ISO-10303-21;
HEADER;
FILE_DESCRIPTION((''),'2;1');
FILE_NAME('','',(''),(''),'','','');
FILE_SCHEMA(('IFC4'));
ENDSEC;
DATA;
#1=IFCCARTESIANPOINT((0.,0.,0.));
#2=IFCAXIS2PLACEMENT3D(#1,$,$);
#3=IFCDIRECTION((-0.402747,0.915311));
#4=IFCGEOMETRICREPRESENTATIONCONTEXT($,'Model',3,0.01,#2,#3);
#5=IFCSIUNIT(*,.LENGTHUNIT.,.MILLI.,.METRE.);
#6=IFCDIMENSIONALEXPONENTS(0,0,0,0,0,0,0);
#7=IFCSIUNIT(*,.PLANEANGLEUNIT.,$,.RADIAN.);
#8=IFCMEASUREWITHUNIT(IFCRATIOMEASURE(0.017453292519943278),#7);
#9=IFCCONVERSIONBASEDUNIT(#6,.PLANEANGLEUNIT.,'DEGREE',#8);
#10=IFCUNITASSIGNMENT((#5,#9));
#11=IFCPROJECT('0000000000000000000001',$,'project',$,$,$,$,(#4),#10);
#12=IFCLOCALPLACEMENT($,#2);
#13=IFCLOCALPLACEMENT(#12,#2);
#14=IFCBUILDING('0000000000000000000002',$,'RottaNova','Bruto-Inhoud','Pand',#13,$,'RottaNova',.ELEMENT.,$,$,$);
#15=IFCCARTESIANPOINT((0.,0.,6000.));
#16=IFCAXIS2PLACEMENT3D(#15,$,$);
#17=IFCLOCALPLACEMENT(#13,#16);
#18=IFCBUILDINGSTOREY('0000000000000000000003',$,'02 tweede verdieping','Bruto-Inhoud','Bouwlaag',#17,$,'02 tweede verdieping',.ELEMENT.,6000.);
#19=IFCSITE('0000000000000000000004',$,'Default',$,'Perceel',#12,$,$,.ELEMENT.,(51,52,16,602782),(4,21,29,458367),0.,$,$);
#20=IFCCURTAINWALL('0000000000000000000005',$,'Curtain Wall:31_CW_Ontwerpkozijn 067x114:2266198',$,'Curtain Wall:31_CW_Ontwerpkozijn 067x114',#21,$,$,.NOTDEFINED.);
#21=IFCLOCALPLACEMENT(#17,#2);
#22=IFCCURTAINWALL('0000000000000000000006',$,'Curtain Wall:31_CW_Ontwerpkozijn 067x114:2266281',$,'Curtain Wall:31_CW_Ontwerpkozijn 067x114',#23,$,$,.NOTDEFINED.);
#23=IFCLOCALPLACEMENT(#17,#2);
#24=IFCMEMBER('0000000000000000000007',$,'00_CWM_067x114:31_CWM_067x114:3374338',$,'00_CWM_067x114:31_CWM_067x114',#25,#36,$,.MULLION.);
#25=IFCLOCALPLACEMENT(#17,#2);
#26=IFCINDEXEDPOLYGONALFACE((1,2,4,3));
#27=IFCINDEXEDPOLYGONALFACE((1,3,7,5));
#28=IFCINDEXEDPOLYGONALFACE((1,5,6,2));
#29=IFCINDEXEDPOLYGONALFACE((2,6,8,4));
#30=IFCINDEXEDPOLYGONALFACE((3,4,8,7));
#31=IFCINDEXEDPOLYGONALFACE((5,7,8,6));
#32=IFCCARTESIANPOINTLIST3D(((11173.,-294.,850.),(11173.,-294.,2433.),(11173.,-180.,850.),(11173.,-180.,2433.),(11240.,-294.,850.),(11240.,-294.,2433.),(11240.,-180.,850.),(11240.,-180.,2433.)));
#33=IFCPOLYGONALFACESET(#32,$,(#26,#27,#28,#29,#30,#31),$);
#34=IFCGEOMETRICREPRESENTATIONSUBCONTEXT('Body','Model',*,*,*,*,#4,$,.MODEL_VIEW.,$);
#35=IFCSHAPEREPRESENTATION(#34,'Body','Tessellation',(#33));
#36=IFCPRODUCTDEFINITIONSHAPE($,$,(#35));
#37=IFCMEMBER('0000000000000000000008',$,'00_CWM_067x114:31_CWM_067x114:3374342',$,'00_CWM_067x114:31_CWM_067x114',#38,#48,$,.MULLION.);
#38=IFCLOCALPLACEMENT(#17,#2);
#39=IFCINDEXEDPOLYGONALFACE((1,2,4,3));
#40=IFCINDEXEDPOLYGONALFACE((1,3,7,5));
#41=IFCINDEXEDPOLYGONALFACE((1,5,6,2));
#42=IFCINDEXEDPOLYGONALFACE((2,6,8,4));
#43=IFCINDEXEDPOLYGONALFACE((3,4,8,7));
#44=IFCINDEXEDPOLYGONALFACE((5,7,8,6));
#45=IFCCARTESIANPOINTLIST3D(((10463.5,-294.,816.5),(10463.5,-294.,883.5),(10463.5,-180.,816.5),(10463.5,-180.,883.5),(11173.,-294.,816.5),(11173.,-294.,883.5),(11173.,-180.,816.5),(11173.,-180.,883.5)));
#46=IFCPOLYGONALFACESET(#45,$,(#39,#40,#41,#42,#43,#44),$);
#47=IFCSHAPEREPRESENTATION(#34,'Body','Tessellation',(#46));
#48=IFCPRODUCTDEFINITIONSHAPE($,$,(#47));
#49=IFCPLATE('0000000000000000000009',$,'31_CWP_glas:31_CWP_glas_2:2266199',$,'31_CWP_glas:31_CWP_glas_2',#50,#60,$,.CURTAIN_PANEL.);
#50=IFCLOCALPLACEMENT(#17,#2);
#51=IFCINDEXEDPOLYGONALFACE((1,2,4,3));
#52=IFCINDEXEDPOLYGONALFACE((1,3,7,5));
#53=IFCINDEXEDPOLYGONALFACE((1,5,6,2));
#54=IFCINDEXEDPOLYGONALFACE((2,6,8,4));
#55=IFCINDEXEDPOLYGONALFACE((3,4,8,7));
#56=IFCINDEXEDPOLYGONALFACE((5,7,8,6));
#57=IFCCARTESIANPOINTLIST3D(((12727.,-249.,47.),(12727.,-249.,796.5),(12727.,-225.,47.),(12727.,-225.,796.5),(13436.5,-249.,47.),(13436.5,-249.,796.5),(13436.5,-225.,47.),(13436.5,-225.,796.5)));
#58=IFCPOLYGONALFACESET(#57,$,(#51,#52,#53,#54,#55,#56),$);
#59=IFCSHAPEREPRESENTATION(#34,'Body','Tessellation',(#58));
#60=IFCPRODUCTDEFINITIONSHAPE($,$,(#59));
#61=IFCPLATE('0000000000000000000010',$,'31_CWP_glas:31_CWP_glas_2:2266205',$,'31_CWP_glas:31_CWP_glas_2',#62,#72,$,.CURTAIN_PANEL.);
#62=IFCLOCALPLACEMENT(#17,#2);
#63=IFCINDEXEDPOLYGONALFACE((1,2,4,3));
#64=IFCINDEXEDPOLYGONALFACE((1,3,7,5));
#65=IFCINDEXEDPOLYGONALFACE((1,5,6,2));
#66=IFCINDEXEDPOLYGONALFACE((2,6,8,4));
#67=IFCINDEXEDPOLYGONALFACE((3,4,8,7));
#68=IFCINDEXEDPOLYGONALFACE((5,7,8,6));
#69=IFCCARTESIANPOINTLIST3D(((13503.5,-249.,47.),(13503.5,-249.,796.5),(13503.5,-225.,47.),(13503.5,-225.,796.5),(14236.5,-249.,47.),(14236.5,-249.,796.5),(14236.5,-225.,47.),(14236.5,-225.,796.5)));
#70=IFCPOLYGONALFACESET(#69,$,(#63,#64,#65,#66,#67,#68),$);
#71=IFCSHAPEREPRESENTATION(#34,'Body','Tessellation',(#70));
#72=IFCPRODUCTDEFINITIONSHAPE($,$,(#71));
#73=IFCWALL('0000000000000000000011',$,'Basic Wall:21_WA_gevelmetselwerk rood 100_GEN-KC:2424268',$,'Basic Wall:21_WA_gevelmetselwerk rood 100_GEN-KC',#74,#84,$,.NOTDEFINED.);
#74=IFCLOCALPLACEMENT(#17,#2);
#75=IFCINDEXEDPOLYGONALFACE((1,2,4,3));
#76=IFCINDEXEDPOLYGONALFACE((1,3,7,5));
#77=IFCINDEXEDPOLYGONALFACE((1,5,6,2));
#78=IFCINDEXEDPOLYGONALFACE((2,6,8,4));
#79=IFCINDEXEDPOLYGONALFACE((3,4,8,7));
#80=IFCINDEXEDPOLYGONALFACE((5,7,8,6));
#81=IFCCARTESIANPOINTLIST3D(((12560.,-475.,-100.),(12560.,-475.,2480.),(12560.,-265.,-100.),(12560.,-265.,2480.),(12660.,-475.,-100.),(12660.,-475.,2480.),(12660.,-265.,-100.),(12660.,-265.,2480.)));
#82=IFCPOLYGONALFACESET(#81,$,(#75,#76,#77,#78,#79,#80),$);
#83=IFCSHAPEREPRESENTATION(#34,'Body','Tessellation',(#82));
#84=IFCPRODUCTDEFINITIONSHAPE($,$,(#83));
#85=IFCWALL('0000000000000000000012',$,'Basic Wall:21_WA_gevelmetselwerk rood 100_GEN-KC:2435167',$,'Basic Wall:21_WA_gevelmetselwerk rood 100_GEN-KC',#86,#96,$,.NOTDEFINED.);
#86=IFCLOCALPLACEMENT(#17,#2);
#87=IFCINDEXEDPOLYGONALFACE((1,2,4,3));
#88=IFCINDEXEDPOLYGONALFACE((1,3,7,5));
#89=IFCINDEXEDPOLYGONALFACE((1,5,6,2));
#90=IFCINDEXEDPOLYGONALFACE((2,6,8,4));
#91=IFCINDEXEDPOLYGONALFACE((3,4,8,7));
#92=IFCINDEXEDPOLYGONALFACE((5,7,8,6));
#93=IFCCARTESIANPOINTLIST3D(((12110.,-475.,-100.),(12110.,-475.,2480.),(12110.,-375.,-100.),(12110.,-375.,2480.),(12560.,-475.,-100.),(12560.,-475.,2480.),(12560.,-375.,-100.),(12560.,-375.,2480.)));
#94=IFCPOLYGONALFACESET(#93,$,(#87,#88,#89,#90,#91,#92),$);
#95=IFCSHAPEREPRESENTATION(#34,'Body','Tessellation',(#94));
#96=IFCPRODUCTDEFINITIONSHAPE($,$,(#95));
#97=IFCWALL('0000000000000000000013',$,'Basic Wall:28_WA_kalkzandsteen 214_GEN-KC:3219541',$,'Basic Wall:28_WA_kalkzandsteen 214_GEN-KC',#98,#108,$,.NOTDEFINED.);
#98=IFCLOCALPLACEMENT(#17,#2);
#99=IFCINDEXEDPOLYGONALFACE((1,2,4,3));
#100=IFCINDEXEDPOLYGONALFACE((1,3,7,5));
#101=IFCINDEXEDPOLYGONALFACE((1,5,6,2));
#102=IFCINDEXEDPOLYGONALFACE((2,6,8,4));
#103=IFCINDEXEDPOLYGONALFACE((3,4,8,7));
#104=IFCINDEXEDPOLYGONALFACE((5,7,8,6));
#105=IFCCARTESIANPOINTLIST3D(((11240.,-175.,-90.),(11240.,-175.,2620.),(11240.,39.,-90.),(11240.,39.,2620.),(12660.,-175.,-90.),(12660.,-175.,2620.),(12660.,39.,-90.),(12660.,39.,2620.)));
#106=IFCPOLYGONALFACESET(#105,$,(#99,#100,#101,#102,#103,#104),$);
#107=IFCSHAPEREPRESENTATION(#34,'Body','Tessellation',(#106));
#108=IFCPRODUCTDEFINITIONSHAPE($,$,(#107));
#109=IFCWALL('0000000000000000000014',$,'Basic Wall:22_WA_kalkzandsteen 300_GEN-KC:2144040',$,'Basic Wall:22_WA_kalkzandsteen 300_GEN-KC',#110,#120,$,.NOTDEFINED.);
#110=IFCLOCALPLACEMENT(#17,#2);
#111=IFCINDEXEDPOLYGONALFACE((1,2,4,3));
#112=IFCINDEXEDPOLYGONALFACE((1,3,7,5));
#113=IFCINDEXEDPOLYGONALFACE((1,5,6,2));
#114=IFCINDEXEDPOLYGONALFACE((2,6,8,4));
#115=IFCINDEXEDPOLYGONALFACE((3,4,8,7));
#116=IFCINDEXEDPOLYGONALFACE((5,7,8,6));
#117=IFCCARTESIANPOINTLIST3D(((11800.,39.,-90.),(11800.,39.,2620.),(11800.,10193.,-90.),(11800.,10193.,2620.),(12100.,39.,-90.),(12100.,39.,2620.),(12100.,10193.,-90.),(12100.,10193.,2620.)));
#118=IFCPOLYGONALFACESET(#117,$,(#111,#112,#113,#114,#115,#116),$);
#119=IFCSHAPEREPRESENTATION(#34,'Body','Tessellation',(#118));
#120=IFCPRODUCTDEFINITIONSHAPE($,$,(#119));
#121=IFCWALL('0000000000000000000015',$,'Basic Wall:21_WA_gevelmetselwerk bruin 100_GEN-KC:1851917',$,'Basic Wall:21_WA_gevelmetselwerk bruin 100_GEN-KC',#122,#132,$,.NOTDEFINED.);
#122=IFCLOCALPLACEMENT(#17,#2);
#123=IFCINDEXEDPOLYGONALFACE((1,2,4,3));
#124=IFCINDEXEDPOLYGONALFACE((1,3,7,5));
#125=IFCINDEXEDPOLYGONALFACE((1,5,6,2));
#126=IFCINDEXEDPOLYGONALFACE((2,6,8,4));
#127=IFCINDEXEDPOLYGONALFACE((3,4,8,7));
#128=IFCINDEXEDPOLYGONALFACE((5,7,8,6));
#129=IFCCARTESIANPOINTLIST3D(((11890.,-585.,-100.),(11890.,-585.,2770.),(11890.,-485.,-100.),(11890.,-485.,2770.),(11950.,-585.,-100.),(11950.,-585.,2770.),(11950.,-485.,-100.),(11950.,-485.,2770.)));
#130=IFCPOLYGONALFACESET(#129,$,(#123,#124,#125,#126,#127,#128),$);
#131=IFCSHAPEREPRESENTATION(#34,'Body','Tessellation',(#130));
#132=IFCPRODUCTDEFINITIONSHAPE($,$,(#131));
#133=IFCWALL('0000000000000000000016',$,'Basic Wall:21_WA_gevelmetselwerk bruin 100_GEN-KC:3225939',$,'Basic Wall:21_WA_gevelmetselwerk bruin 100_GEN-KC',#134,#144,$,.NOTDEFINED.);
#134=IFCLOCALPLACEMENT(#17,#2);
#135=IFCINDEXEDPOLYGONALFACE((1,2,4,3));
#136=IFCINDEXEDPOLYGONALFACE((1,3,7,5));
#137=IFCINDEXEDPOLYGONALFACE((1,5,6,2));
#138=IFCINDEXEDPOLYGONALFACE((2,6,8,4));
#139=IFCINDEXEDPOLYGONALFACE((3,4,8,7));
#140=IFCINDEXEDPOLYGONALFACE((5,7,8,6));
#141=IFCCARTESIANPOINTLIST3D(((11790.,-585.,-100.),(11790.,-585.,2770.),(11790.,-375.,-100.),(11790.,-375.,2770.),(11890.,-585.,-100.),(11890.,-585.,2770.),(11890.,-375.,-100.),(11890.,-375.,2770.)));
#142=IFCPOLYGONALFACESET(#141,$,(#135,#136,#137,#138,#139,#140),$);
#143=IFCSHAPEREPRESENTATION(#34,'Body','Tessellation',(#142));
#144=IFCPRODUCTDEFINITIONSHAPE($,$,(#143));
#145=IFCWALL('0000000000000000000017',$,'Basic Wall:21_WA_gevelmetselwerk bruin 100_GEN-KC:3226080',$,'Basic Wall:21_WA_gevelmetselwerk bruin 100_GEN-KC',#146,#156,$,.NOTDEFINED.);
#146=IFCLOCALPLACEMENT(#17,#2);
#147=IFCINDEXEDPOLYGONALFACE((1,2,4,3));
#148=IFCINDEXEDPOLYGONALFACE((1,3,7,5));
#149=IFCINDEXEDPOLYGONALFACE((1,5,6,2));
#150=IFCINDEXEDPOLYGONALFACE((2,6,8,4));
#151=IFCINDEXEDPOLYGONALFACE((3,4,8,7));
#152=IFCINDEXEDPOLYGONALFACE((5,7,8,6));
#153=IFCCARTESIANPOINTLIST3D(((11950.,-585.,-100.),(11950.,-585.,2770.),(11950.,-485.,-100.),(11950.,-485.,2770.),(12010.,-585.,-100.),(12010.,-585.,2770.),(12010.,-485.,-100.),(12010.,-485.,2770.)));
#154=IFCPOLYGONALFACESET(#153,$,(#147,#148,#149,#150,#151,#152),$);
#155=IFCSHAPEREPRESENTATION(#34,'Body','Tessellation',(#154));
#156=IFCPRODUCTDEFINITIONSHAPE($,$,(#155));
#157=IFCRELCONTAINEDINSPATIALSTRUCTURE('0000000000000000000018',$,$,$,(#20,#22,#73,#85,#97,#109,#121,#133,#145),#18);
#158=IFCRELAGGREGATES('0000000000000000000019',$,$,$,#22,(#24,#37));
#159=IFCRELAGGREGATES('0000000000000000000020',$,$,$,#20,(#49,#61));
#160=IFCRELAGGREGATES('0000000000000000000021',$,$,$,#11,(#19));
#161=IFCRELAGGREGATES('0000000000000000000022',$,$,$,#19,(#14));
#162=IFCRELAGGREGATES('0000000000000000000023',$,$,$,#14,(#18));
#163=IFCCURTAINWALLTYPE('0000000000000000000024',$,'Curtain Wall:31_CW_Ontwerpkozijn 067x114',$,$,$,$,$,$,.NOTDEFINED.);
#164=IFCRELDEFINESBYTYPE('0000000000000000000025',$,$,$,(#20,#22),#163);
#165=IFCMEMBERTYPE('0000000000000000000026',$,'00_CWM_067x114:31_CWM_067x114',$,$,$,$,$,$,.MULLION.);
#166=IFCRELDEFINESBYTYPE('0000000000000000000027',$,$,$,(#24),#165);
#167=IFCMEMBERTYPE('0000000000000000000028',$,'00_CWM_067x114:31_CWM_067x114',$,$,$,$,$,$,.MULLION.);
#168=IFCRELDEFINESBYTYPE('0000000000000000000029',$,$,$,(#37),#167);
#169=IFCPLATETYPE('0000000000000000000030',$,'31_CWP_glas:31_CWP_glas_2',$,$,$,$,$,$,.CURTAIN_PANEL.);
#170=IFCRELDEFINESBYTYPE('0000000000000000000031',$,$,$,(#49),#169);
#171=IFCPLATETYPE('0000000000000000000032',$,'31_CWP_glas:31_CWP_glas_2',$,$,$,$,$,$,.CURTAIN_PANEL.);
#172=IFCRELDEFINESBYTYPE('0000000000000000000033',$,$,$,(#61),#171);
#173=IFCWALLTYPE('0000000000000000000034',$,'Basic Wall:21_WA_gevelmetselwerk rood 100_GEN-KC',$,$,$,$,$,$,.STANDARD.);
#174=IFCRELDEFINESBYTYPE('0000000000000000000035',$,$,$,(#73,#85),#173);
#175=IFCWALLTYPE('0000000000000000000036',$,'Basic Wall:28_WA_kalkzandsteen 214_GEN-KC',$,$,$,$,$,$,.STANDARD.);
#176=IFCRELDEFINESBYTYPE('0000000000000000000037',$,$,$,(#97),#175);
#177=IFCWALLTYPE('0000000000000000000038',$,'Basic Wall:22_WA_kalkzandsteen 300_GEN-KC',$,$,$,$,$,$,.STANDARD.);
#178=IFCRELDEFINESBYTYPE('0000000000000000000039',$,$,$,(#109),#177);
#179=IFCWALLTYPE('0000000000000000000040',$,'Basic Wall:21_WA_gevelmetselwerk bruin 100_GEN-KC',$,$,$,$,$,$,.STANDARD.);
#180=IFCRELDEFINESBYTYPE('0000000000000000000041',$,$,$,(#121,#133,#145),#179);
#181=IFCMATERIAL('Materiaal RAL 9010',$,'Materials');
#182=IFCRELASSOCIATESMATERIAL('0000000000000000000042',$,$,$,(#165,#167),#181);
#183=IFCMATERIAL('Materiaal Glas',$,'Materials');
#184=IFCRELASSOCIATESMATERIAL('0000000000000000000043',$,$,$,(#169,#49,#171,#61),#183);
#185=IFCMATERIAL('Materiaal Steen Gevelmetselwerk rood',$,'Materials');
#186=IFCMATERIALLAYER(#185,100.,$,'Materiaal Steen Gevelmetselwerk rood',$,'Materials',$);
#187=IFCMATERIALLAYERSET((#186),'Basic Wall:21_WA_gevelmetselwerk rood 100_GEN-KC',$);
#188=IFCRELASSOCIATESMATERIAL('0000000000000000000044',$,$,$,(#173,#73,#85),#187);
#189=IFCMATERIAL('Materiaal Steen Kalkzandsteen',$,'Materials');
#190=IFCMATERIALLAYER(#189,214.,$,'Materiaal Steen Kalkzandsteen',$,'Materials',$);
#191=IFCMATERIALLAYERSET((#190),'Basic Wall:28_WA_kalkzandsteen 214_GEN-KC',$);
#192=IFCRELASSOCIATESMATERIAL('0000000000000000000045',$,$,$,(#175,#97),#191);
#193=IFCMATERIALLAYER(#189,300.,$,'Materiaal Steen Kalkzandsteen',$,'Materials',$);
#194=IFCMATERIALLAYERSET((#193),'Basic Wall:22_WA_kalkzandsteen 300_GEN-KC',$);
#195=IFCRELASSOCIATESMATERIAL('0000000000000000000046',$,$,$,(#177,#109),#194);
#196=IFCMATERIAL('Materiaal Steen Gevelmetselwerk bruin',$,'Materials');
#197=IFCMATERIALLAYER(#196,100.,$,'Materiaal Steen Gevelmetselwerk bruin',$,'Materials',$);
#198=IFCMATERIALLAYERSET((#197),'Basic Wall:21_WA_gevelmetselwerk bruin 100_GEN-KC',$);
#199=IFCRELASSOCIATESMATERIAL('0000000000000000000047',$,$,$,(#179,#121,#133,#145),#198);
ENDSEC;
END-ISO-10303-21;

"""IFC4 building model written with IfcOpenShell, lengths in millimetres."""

from ifc_helpers import new_model, entity, si_unit, converted_unit, direction, frame, frame_2d, origin, origin_2d_with_axis, place, context, subcontext, project, spatial, rectangle, extrude, source, transform, mapped, material, layer, layer_set, material_profile, profile_set, type_object, type_shapes, element, aggregate, save


model = new_model("IFC4")

# Units and contexts
model_context = context("Model", 3, precision=0.01, world=origin(), true_north=direction((-0.402747, 0.915311)))
body_context = subcontext(model_context, "Body", "Model", "MODEL_VIEW")
ifc_project = project(units=[si_unit("LENGTHUNIT", "METRE", prefix="MILLI"), converted_unit("PLANEANGLEUNIT", "DEGREE", entity("IfcRatioMeasure", 0.017453292519943278), si_unit("PLANEANGLEUNIT", "RADIAN"), dimensions=[0, 0, 0, 0, 0, 0, 0])], contexts=[model_context])

# Site, building, storey
site_placement = place(None, origin())
site = spatial("IfcSite", under=ifc_project, at=site_placement, Name="Default", ObjectType="Perceel", CompositionType="ELEMENT", RefLatitude=(51, 52, 16, 602782), RefLongitude=(4, 21, 29, 458367), RefElevation=0.0)
building_placement = place(site_placement, origin())
building = spatial("IfcBuilding", under=site, at=building_placement, Name="RottaNova", Description="Bruto-Inhoud", ObjectType="Pand", LongName="RottaNova", CompositionType="ELEMENT")
storey_placement = place(building_placement, frame((0.0, 0.0, 6000.0)))
storey = spatial("IfcBuildingStorey", under=building, at=storey_placement, Name="02 tweede verdieping", Description="Bruto-Inhoud", ObjectType="Bouwlaag", LongName="02 tweede verdieping", CompositionType="ELEMENT", Elevation=6000.0)

# Curtain walls, members
curtain_wall_type = type_object("IfcCurtainWallType", Name="Curtain Wall:31_CW_Ontwerpkozijn 067x114", PredefinedType="NOTDEFINED")
curtain_wall_1_placement = place(storey_placement, frame((0.0, 0.0, -6000.0)))
curtain_wall_1 = element("IfcCurtainWall", 1, at=curtain_wall_1_placement, inside=storey, type_object=curtain_wall_type, Name="Curtain Wall:31_CW_Ontwerpkozijn 067x114:2266198", ObjectType="Curtain Wall:31_CW_Ontwerpkozijn 067x114", PredefinedType="NOTDEFINED")
curtain_wall_2_placement = place(storey_placement, frame((0.0, 0.0, -6000.0)))
curtain_wall_2 = element("IfcCurtainWall", 2, at=curtain_wall_2_placement, inside=storey, type_object=curtain_wall_type, Name="Curtain Wall:31_CW_Ontwerpkozijn 067x114:2266281", ObjectType="Curtain Wall:31_CW_Ontwerpkozijn 067x114", PredefinedType="NOTDEFINED")
ifc_material_1 = material(Name="Materiaal RAL 9010", Category="Materials")
ifc_material_profile_1 = material_profile(ifc_material_1, rectangle(XDim=114.0, YDim=67.0, at=origin_2d_with_axis()), Name="31_CWM_067x114")
ifc_profile_set_1 = profile_set([ifc_material_profile_1], Name="31_CWM_067x114")
member_type_1 = type_object("IfcMemberType", Name="00_CWM_067x114:31_CWM_067x114", PredefinedType="MULLION", material=ifc_profile_set_1)
shared_shape_1 = source(origin(), body_context, "Body", "SweptSolid", [
    extrude(rectangle(XDim=114.0, YDim=67.0, at=origin_2d_with_axis()), frame((-33.5, 57.0, -1583.0), z_axis=(0.0, 0.0, 1.0), x_axis=(0.0, -1.0, 0.0)), (0.0, 0.0, 1.0), 1583.0),
])
type_shapes(member_type_1, [shared_shape_1])
member_1_placement = place(curtain_wall_2_placement, frame((11240.0, -180.0, 6850.0), z_axis=(0.0, 0.0, -1.0), x_axis=(1.0, 0.0, 0.0)))
member_1 = element("IfcMember", 3, at=member_1_placement, type_object=member_type_1, Name="00_CWM_067x114:31_CWM_067x114:3374338", ObjectType="00_CWM_067x114:31_CWM_067x114", PredefinedType="MULLION", context=body_context, shape_type="MappedRepresentation", body=[
    mapped(shared_shape_1, transform((0.0, 0.0, 0.0), scale=1.0)),
])
member_type_2 = type_object("IfcMemberType", Name="00_CWM_067x114:31_CWM_067x114", PredefinedType="MULLION", material=ifc_profile_set_1)
shared_shape_2 = source(origin(), body_context, "Body", "SweptSolid", [
    extrude(rectangle(XDim=114.0, YDim=67.0, at=origin_2d_with_axis()), frame((0.0, 57.0, -709.5), z_axis=(0.0, 0.0, 1.0), x_axis=(0.0, -1.0, 0.0)), (0.0, 0.0, 1.0), 709.5),
])
type_shapes(member_type_2, [shared_shape_2])
member_2_placement = place(curtain_wall_2_placement, frame((11173.0, -180.0, 6850.0), z_axis=(1.0, 0.0, 0.0), x_axis=(0.0, 0.0, 1.0)))
member_2 = element("IfcMember", 4, at=member_2_placement, type_object=member_type_2, Name="00_CWM_067x114:31_CWM_067x114:3374342", ObjectType="00_CWM_067x114:31_CWM_067x114", PredefinedType="MULLION", context=body_context, shape_type="MappedRepresentation", body=[
    mapped(shared_shape_2, transform((0.0, 0.0, 0.0), scale=1.0)),
])
aggregate(curtain_wall_2, [member_1, member_2])

# Plates
ifc_material_2 = material(Name="Materiaal Glas", Category="Materials")
plate_type_1 = type_object("IfcPlateType", Name="31_CWP_glas:31_CWP_glas_2", PredefinedType="CURTAIN_PANEL", material=ifc_material_2)
shared_shape_3 = source(origin(), body_context, "Body", "SweptSolid", [
    extrude(rectangle(XDim=24.0, YDim=709.5, at=frame_2d((0.0, 0.0), x_axis=(1.0, 0.0))), frame((354.8, 12.0, 0.0), z_axis=(0.0, 0.0, 1.0), x_axis=(0.0, 1.0, 0.0)), (0.0, 0.0, 1.0), 749.5),
])
type_shapes(plate_type_1, [shared_shape_3])
plate_1_placement = place(curtain_wall_1_placement, frame((12727.0, -249.0, 6047.0)))
plate_1 = element("IfcPlate", 5, at=plate_1_placement, type_object=plate_type_1, material=ifc_material_2, Name="31_CWP_glas:31_CWP_glas_2:2266199", ObjectType="31_CWP_glas:31_CWP_glas_2", PredefinedType="CURTAIN_PANEL", context=body_context, shape_type="MappedRepresentation", body=[
    mapped(shared_shape_3, transform((0.0, 0.0, 0.0), scale=1.0)),
])
plate_type_2 = type_object("IfcPlateType", Name="31_CWP_glas:31_CWP_glas_2", PredefinedType="CURTAIN_PANEL", material=ifc_material_2)
shared_shape_4 = source(origin(), body_context, "Body", "SweptSolid", [
    extrude(rectangle(XDim=24.0, YDim=733.0, at=frame_2d((0.0, 0.0), x_axis=(1.0, 0.0))), frame((366.5, 12.0, 0.0), z_axis=(0.0, 0.0, 1.0), x_axis=(0.0, 1.0, 0.0)), (0.0, 0.0, 1.0), 749.5),
])
type_shapes(plate_type_2, [shared_shape_4])
plate_2_placement = place(curtain_wall_1_placement, frame((13503.5, -249.0, 6047.0)))
plate_2 = element("IfcPlate", 6, at=plate_2_placement, type_object=plate_type_2, material=ifc_material_2, Name="31_CWP_glas:31_CWP_glas_2:2266205", ObjectType="31_CWP_glas:31_CWP_glas_2", PredefinedType="CURTAIN_PANEL", context=body_context, shape_type="MappedRepresentation", body=[
    mapped(shared_shape_4, transform((0.0, 0.0, 0.0), scale=1.0)),
])

# Walls
ifc_material_3 = material(Name="Materiaal Steen Gevelmetselwerk rood", Category="Materials")
ifc_layer_1 = layer(ifc_material_3, 100.0, Name="Materiaal Steen Gevelmetselwerk rood", Category="Materials")
ifc_layer_set_1 = layer_set([ifc_layer_1], Name="Basic Wall:21_WA_gevelmetselwerk rood 100_GEN-KC")
wall_type_1 = type_object("IfcWallType", Name="Basic Wall:21_WA_gevelmetselwerk rood 100_GEN-KC", PredefinedType="STANDARD", material=ifc_layer_set_1)
wall_1_placement = place(storey_placement, frame((12610.0, -265.0, -100.0), z_axis=(0.0, 0.0, 1.0), x_axis=(0.0, -1.0, 0.0)))
element("IfcWall", 7, at=wall_1_placement, inside=storey, type_object=wall_type_1, material=ifc_layer_set_1, Name="Basic Wall:21_WA_gevelmetselwerk rood 100_GEN-KC:2424268", ObjectType="Basic Wall:21_WA_gevelmetselwerk rood 100_GEN-KC", PredefinedType="NOTDEFINED", context=body_context, shape_type="SweptSolid", body=[
    extrude(rectangle(XDim=210.0, YDim=100.0, at=frame_2d((105.0, 0.0), x_axis=(-1.0, 0.0))), origin(), (0.0, 0.0, 1.0), 2580.0),
])
wall_2_placement = place(storey_placement, frame((12560.0, -425.0, -100.0), z_axis=(0.0, 0.0, 1.0), x_axis=(-1.0, 0.0, 0.0)))
element("IfcWall", 8, at=wall_2_placement, inside=storey, type_object=wall_type_1, material=ifc_layer_set_1, Name="Basic Wall:21_WA_gevelmetselwerk rood 100_GEN-KC:2435167", ObjectType="Basic Wall:21_WA_gevelmetselwerk rood 100_GEN-KC", PredefinedType="NOTDEFINED", context=body_context, shape_type="SweptSolid", body=[
    extrude(rectangle(XDim=450.0, YDim=100.0, at=frame_2d((225.0, 0.0), x_axis=(-1.0, 0.0))), origin(), (0.0, 0.0, 1.0), 2580.0),
])
ifc_material_4 = material(Name="Materiaal Steen Kalkzandsteen", Category="Materials")
ifc_layer_2 = layer(ifc_material_4, 214.0, Name="Materiaal Steen Kalkzandsteen", Category="Materials")
ifc_layer_set_2 = layer_set([ifc_layer_2], Name="Basic Wall:28_WA_kalkzandsteen 214_GEN-KC")
wall_type_2 = type_object("IfcWallType", Name="Basic Wall:28_WA_kalkzandsteen 214_GEN-KC", PredefinedType="STANDARD", material=ifc_layer_set_2)
wall_3_placement = place(storey_placement, frame((12660.0, -68.0, -90.0), z_axis=(0.0, 0.0, 1.0), x_axis=(-1.0, 0.0, 0.0)))
element("IfcWall", 9, at=wall_3_placement, inside=storey, type_object=wall_type_2, material=ifc_layer_set_2, Name="Basic Wall:28_WA_kalkzandsteen 214_GEN-KC:3219541", ObjectType="Basic Wall:28_WA_kalkzandsteen 214_GEN-KC", PredefinedType="NOTDEFINED", context=body_context, shape_type="SweptSolid", body=[
    extrude(rectangle(XDim=1420.0, YDim=214.0, at=frame_2d((710.0, 0.0), x_axis=(-1.0, 0.0))), origin(), (0.0, 0.0, 1.0), 2710.0),
])
ifc_layer_3 = layer(ifc_material_4, 300.0, Name="Materiaal Steen Kalkzandsteen", Category="Materials")
ifc_layer_set_3 = layer_set([ifc_layer_3], Name="Basic Wall:22_WA_kalkzandsteen 300_GEN-KC")
wall_type_3 = type_object("IfcWallType", Name="Basic Wall:22_WA_kalkzandsteen 300_GEN-KC", PredefinedType="STANDARD", material=ifc_layer_set_3)
wall_4_placement = place(storey_placement, frame((11950.0, 39.0, -90.0), z_axis=(0.0, 0.0, 1.0), x_axis=(0.0, 1.0, 0.0)))
element("IfcWall", 10, at=wall_4_placement, inside=storey, type_object=wall_type_3, material=ifc_layer_set_3, Name="Basic Wall:22_WA_kalkzandsteen 300_GEN-KC:2144040", ObjectType="Basic Wall:22_WA_kalkzandsteen 300_GEN-KC", PredefinedType="NOTDEFINED", context=body_context, shape_type="SweptSolid", body=[
    extrude(rectangle(XDim=10154.0, YDim=300.0, at=frame_2d((5077.0, 0.0), x_axis=(-1.0, 0.0))), origin(), (0.0, 0.0, 1.0), 2710.0),
])
ifc_material_5 = material(Name="Materiaal Steen Gevelmetselwerk bruin", Category="Materials")
ifc_layer_4 = layer(ifc_material_5, 100.0, Name="Materiaal Steen Gevelmetselwerk bruin", Category="Materials")
ifc_layer_set_4 = layer_set([ifc_layer_4], Name="Basic Wall:21_WA_gevelmetselwerk bruin 100_GEN-KC")
wall_type_4 = type_object("IfcWallType", Name="Basic Wall:21_WA_gevelmetselwerk bruin 100_GEN-KC", PredefinedType="STANDARD", material=ifc_layer_set_4)
wall_5_placement = place(storey_placement, frame((11890.0, -535.0, -100.0)))
element("IfcWall", 11, at=wall_5_placement, inside=storey, type_object=wall_type_4, material=ifc_layer_set_4, Name="Basic Wall:21_WA_gevelmetselwerk bruin 100_GEN-KC:1851917", ObjectType="Basic Wall:21_WA_gevelmetselwerk bruin 100_GEN-KC", PredefinedType="NOTDEFINED", context=body_context, shape_type="SweptSolid", body=[
    extrude(rectangle(XDim=60.0, YDim=100.0, at=frame_2d((30.0, 0.0), x_axis=(-1.0, 0.0))), origin(), (0.0, 0.0, 1.0), 2870.0),
])
wall_6_placement = place(storey_placement, frame((11840.0, -585.0, -100.0), z_axis=(0.0, 0.0, 1.0), x_axis=(0.0, 1.0, 0.0)))
element("IfcWall", 12, at=wall_6_placement, inside=storey, type_object=wall_type_4, material=ifc_layer_set_4, Name="Basic Wall:21_WA_gevelmetselwerk bruin 100_GEN-KC:3225939", ObjectType="Basic Wall:21_WA_gevelmetselwerk bruin 100_GEN-KC", PredefinedType="NOTDEFINED", context=body_context, shape_type="SweptSolid", body=[
    extrude(rectangle(XDim=210.0, YDim=100.0, at=frame_2d((105.0, 0.0), x_axis=(-1.0, 0.0))), origin(), (0.0, 0.0, 1.0), 2870.0),
])
wall_7_placement = place(storey_placement, frame((12010.0, -535.0, -100.0), z_axis=(0.0, 0.0, 1.0), x_axis=(-1.0, 0.0, 0.0)))
element("IfcWall", 13, at=wall_7_placement, inside=storey, type_object=wall_type_4, material=ifc_layer_set_4, Name="Basic Wall:21_WA_gevelmetselwerk bruin 100_GEN-KC:3226080", ObjectType="Basic Wall:21_WA_gevelmetselwerk bruin 100_GEN-KC", PredefinedType="NOTDEFINED", context=body_context, shape_type="SweptSolid", body=[
    extrude(rectangle(XDim=60.0, YDim=100.0, at=frame_2d((30.0, 0.0), x_axis=(-1.0, 0.0))), origin(), (0.0, 0.0, 1.0), 2870.0),
])

aggregate(curtain_wall_1, [plate_1, plate_2])

save(model, "model.ifc")
